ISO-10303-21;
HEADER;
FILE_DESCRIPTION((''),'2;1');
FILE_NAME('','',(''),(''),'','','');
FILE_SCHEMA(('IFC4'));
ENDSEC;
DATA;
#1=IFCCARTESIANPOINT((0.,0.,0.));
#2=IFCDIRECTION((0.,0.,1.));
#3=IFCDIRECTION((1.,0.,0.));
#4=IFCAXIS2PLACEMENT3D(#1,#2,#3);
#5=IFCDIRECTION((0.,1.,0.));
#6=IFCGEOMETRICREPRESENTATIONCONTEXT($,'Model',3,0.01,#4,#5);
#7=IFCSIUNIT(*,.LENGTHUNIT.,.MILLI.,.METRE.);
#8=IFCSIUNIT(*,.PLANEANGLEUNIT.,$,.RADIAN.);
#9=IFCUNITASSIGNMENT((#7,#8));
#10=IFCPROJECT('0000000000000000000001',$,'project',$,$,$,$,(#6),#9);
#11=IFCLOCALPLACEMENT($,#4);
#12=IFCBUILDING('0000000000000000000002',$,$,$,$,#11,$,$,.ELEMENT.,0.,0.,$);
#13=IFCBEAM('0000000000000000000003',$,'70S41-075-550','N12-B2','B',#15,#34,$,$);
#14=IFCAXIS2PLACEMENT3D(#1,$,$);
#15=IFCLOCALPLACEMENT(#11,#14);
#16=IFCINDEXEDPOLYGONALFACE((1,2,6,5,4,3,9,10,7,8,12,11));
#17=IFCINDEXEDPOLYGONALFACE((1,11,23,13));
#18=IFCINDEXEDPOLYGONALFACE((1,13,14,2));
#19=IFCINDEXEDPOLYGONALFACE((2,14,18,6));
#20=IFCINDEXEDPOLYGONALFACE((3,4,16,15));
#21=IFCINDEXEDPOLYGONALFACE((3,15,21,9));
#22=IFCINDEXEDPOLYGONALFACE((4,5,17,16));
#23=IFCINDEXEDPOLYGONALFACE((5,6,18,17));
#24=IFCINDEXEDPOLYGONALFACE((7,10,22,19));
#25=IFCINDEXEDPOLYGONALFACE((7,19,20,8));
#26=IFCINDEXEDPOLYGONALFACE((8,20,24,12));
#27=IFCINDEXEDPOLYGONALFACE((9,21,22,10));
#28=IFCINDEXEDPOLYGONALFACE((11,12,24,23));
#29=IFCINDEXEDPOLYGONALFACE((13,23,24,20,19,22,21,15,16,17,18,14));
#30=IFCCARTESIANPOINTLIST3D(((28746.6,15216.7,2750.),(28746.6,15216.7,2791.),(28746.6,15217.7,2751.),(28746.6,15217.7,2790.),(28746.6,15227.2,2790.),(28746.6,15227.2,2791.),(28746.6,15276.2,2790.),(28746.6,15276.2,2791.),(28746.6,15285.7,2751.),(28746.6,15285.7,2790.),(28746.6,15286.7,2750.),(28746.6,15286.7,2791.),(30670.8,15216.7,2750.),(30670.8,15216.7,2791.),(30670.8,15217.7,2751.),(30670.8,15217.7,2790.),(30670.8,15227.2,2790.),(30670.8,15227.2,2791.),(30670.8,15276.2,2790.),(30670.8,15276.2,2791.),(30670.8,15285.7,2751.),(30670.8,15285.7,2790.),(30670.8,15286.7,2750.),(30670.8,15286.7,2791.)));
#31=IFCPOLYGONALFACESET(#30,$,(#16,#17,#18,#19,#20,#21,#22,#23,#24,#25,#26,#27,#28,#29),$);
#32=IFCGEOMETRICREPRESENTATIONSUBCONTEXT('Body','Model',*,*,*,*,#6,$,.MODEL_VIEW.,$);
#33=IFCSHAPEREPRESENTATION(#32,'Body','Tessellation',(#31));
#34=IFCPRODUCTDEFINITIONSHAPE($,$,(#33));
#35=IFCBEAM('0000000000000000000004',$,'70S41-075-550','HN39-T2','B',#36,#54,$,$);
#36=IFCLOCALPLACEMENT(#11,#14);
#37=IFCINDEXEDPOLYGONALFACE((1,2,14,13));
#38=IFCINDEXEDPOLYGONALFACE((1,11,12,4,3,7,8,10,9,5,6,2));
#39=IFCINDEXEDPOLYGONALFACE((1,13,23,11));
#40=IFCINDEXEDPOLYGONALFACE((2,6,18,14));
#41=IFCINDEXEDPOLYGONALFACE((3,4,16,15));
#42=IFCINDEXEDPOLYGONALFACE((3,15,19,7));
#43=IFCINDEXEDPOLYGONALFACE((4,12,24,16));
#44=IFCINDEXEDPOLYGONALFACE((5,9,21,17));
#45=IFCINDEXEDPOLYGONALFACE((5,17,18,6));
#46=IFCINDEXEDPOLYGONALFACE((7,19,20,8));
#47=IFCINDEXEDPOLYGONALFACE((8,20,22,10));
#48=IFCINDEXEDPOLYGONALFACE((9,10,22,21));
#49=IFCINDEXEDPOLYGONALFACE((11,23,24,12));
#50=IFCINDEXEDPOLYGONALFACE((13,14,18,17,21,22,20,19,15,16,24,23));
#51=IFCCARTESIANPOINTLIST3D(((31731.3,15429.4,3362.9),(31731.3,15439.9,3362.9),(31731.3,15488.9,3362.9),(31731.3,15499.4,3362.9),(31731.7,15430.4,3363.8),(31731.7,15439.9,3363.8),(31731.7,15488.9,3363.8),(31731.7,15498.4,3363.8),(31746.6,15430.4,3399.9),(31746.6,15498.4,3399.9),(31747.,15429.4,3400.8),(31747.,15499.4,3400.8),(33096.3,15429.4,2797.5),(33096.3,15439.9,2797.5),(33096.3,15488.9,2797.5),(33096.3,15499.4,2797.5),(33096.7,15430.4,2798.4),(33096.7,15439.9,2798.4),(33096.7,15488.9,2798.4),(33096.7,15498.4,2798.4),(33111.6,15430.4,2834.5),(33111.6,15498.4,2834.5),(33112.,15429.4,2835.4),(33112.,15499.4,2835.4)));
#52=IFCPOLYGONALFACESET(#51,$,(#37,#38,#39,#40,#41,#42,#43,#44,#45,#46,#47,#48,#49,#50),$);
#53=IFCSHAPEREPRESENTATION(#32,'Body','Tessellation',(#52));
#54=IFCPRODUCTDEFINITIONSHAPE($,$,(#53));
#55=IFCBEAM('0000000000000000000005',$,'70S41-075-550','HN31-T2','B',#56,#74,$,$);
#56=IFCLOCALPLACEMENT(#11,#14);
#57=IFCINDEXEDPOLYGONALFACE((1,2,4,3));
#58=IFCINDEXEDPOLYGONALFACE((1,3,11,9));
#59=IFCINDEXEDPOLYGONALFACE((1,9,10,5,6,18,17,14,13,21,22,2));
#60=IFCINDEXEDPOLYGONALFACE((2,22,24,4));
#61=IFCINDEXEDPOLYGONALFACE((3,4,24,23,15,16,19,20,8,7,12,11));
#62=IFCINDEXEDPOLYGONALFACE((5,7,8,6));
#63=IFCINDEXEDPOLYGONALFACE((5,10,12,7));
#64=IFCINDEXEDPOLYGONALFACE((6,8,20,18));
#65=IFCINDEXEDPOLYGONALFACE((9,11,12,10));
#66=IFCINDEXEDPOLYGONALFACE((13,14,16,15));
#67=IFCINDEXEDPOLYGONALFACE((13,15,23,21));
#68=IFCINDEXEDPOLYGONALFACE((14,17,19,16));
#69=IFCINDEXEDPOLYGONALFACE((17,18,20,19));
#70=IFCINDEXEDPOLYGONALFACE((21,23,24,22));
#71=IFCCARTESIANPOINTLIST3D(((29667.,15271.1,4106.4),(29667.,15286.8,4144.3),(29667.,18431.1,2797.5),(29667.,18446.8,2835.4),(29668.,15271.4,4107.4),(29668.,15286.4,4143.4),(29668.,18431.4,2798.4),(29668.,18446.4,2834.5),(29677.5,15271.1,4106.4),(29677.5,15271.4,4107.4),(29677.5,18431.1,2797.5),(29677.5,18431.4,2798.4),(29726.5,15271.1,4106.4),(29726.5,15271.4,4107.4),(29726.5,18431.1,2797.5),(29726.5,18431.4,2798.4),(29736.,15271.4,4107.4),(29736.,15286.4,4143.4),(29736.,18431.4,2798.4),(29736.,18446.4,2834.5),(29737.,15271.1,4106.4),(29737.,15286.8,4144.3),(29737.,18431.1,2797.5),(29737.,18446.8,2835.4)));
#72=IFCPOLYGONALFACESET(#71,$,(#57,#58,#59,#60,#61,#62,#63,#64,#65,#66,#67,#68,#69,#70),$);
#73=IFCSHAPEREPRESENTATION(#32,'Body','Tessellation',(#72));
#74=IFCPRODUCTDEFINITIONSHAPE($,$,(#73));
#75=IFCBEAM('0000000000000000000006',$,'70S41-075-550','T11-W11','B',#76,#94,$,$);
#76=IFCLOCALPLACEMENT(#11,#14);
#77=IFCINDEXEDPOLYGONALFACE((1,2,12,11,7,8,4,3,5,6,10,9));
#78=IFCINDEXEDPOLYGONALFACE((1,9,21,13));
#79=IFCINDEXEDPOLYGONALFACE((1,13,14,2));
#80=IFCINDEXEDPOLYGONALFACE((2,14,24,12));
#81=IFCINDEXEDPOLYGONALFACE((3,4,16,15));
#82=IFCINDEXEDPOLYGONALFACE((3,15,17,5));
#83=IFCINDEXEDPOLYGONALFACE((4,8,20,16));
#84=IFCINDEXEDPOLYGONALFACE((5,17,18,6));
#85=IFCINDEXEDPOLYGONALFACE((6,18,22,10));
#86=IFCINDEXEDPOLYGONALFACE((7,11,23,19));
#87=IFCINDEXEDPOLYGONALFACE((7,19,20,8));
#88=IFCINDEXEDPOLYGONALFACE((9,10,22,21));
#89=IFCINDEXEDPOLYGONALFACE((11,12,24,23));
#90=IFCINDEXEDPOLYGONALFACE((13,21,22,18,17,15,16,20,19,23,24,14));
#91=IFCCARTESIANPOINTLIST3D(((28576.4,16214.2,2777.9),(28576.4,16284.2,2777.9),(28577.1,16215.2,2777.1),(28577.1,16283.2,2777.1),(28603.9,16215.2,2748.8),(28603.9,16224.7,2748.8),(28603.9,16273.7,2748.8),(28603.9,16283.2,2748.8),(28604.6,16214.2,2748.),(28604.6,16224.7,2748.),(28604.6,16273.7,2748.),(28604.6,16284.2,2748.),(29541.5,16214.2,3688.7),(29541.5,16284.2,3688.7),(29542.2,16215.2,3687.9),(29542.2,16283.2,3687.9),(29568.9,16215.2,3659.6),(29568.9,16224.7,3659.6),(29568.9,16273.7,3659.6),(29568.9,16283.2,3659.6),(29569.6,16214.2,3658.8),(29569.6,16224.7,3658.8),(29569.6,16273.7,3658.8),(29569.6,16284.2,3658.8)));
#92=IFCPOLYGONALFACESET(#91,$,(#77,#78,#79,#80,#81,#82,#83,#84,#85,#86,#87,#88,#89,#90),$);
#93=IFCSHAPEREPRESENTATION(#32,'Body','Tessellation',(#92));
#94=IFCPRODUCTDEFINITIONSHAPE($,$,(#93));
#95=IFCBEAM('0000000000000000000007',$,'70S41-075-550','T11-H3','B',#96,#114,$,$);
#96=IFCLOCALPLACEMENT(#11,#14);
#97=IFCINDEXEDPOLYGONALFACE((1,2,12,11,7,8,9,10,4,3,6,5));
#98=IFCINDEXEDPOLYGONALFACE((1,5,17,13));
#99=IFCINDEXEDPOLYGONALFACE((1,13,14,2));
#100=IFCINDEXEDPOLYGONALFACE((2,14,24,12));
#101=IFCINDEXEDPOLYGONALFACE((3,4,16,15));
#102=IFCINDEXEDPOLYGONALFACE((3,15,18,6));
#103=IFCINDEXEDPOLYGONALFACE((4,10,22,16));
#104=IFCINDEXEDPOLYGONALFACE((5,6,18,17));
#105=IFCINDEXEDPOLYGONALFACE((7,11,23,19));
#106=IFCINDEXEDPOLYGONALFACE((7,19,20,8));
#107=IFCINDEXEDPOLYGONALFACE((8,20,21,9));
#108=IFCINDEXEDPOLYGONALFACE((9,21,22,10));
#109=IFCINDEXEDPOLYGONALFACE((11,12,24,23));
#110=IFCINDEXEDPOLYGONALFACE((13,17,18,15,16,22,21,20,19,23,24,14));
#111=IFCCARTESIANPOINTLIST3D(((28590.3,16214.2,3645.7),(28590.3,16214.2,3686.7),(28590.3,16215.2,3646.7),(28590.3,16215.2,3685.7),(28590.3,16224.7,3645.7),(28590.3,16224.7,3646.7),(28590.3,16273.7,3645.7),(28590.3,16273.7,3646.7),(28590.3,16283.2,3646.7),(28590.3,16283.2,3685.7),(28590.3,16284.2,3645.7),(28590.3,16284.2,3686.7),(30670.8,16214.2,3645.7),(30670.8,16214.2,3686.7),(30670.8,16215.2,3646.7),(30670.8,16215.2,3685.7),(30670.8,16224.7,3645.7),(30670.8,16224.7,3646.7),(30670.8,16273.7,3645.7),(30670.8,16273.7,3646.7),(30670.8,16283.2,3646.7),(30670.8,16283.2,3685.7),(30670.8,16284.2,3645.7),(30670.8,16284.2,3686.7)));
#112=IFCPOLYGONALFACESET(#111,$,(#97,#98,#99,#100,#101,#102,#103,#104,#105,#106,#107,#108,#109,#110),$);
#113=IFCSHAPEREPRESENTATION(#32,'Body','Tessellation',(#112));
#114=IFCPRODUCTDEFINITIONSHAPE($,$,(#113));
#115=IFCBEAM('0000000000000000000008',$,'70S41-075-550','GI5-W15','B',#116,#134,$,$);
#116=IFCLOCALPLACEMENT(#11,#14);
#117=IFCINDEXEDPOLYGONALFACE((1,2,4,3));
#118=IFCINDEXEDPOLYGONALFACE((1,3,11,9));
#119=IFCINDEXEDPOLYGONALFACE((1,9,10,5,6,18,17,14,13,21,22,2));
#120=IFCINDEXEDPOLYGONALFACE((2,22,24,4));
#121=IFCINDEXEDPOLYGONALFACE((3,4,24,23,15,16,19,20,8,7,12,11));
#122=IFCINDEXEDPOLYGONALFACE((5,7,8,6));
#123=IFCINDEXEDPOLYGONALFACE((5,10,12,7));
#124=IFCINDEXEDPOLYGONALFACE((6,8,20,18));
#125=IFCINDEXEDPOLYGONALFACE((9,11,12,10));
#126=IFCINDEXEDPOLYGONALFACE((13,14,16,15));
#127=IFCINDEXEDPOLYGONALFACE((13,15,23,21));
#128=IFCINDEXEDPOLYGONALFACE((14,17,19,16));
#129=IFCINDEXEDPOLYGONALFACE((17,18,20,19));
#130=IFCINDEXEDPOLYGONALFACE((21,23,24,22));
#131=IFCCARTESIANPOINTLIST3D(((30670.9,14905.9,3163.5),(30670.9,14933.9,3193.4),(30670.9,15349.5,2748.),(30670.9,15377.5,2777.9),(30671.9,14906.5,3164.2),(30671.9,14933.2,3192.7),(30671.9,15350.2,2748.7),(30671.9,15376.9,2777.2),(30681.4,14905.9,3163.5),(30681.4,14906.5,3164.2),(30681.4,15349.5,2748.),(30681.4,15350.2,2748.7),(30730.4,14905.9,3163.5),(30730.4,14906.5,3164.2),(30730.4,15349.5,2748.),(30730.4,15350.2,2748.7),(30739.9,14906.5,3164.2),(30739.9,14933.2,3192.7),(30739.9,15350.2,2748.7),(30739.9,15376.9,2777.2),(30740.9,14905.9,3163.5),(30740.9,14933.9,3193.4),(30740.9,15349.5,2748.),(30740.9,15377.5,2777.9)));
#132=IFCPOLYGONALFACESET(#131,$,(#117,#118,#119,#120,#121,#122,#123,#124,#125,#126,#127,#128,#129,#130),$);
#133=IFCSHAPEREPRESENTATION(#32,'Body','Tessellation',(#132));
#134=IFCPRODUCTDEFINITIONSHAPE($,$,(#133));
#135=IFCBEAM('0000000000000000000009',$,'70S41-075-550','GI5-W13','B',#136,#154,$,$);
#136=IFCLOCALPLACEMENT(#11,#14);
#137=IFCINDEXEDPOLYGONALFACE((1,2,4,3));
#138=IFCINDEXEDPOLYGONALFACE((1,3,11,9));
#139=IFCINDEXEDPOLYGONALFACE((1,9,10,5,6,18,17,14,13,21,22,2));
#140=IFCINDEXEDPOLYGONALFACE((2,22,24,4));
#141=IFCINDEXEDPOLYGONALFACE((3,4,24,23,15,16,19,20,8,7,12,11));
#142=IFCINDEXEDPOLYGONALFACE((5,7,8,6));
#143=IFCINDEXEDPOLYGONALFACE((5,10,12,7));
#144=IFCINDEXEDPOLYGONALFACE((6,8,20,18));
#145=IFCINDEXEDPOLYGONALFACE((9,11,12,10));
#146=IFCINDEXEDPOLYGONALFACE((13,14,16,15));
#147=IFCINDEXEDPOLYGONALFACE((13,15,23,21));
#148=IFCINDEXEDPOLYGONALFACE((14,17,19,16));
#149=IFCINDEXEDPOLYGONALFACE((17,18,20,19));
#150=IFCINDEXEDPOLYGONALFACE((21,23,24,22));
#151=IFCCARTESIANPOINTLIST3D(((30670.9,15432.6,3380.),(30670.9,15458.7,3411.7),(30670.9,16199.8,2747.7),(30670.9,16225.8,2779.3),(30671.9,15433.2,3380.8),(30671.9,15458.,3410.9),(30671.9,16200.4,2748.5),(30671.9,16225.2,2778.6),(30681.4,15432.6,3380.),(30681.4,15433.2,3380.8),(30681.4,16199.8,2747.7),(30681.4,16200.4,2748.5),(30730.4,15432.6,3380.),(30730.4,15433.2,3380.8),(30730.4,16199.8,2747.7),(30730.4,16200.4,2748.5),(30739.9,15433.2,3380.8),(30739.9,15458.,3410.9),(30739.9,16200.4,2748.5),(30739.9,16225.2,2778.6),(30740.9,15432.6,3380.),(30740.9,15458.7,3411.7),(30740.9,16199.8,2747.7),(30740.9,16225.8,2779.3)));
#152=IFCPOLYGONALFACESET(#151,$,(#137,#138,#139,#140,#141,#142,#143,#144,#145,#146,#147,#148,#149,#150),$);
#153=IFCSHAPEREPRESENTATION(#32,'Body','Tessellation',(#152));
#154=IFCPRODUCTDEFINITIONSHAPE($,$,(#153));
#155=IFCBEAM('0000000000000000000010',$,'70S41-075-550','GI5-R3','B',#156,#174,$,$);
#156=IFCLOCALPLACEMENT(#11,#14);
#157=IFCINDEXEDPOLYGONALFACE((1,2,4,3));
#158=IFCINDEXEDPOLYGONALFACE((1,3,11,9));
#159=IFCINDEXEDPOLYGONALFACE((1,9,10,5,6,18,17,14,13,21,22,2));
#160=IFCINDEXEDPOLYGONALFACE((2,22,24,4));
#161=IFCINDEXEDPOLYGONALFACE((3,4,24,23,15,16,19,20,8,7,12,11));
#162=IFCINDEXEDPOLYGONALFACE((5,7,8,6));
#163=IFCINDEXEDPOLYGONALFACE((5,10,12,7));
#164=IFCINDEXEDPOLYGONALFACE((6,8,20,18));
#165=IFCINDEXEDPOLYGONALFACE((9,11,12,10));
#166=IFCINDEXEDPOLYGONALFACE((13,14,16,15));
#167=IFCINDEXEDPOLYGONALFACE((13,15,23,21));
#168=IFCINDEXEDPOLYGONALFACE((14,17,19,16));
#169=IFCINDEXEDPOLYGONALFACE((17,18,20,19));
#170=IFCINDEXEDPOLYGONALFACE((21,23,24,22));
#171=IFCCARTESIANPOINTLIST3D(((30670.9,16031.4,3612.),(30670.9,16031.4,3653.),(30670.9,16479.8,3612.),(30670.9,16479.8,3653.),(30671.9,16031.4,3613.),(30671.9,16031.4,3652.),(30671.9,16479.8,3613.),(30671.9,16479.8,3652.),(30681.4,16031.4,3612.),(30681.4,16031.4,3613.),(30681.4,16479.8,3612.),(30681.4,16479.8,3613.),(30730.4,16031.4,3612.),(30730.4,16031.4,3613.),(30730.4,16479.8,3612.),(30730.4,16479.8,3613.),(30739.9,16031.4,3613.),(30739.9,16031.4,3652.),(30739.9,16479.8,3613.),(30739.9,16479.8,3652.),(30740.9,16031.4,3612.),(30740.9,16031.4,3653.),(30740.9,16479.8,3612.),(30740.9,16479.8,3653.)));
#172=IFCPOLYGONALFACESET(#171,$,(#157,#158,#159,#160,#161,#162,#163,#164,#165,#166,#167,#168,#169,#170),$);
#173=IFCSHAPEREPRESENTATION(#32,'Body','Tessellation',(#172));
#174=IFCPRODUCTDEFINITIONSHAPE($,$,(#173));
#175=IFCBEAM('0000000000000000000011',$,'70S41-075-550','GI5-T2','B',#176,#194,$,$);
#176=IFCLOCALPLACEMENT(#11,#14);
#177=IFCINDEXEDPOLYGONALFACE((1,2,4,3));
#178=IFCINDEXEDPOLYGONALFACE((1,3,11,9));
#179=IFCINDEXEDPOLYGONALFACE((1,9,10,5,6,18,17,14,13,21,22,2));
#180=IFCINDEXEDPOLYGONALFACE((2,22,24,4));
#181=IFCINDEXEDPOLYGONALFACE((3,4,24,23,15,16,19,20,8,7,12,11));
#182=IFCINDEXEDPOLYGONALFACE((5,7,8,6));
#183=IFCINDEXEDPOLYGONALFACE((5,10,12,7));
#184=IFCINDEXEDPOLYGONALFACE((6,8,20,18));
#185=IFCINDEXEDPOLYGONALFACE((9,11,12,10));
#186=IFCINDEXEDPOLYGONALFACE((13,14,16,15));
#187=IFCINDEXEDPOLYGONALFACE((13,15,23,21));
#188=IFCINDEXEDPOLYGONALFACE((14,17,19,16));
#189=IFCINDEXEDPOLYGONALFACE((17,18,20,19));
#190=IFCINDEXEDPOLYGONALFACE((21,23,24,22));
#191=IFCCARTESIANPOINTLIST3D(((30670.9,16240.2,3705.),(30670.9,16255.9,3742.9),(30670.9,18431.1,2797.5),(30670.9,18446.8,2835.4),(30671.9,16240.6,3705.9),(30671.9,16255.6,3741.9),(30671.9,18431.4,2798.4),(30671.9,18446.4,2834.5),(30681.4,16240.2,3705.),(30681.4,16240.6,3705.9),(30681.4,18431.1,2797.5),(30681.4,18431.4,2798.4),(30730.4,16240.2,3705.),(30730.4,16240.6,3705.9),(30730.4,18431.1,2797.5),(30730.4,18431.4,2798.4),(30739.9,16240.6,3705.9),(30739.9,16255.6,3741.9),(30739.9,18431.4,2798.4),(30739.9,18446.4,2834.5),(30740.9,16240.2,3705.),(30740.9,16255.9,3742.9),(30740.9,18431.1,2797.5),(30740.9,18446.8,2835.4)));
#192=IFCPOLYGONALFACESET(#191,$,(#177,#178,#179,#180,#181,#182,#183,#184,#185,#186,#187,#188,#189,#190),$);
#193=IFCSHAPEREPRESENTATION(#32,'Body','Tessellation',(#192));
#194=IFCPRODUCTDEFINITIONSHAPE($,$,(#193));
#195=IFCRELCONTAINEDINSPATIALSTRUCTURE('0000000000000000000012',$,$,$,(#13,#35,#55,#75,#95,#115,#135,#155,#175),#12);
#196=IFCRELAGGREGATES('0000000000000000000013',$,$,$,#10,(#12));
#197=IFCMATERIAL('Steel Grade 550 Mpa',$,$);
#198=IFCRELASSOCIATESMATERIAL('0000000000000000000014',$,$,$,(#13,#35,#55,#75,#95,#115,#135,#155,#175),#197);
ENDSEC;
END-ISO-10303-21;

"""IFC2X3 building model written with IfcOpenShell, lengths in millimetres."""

from ifc_helpers import new_model, si_unit, direction, frame, origin, origin_with_axes, origin_2d_with_axis, place, context, subcontext, project, spatial, c_section, extrude, source, transform, mapped, material, element, save


model = new_model("IFC2X3")

# Units and contexts
model_context = context("Model", 3, precision=0.01, world=origin_with_axes(), true_north=direction((0.0, 1.0, 0.0)))
body_context = subcontext(model_context, "Body", "Model", "MODEL_VIEW")
ifc_project = project(units=[si_unit("LENGTHUNIT", "METRE", prefix="MILLI"), si_unit("PLANEANGLEUNIT", "RADIAN")], contexts=[model_context])

# Building
building_placement = place(None, origin_with_axes())
building = spatial("IfcBuilding", under=ifc_project, at=building_placement, CompositionType="ELEMENT", ElevationOfRefHeight=0.0, ElevationOfTerrain=0.0)

# Shared definitions
ifc_material = material(Name="Steel Grade 550 Mpa")

# Beams
shared_shape_1 = source(origin(), body_context, "Body", "SweptSolid", [
    extrude(c_section(Depth=70.0, Width=41.0, WallThickness=1.0, Girth=10.5, at=origin_2d_with_axis()), origin_with_axes(), (0.0, 0.0, 1.0), 1924.2),
])
beam_1_placement = place(None, frame((28746.6, 15251.7, 2770.5), z_axis=(1.0, 0.0, 0.0), x_axis=(0.0, 0.0, 1.0)))
element("IfcBeam", 1, at=beam_1_placement, inside=building, material=ifc_material, Name="70S41-075-550", Description="N12-B2", ObjectType="B", context=body_context, shape_type="MappedRepresentation", body=[
    mapped(shared_shape_1, transform((0.0, 0.0, 0.0), scale=1.0)),
])
shared_shape_2 = source(origin(), body_context, "Body", "SweptSolid", [
    extrude(c_section(Depth=70.0, Width=41.0, WallThickness=1.0, Girth=10.5, at=origin_2d_with_axis()), origin_with_axes(), (0.0, 0.0, 1.0), 1477.5),
])
beam_2_placement = place(None, frame((31739.2, 15464.4, 3381.9), z_axis=(0.92388, 0.0, -0.382683), x_axis=(-0.382683, 0.0, -0.92388)))
element("IfcBeam", 2, at=beam_2_placement, inside=building, material=ifc_material, Name="70S41-075-550", Description="HN39-T2", ObjectType="B", context=body_context, shape_type="MappedRepresentation", body=[
    mapped(shared_shape_2, transform((0.0, 0.0, 0.0), scale=1.0)),
])
shared_shape_3 = source(origin(), body_context, "Body", "SweptSolid", [
    extrude(c_section(Depth=70.0, Width=41.0, WallThickness=1.0, Girth=10.5, at=origin_2d_with_axis()), origin_with_axes(), (0.0, 0.0, 1.0), 3420.4),
])
beam_3_placement = place(None, frame((29702.0, 15278.9, 4125.4), z_axis=(0.0, 0.92388, -0.382683), x_axis=(0.0, -0.382683, -0.92388)))
element("IfcBeam", 3, at=beam_3_placement, inside=building, material=ifc_material, Name="70S41-075-550", Description="HN31-T2", ObjectType="B", context=body_context, shape_type="MappedRepresentation", body=[
    mapped(shared_shape_3, transform((0.0, 0.0, 0.0), scale=1.0)),
])
shared_shape_4 = source(origin(), body_context, "Body", "SweptSolid", [
    extrude(c_section(Depth=70.0, Width=41.0, WallThickness=1.0, Girth=10.5, at=origin_2d_with_axis()), origin_with_axes(), (0.0, 0.0, 1.0), 1327.0),
])
beam_4_placement = place(None, frame((29555.5, 16249.2, 3673.8), z_axis=(-0.727249, 0.0, -0.686374), x_axis=(0.686374, 0.0, -0.727249)))
element("IfcBeam", 4, at=beam_4_placement, inside=building, material=ifc_material, Name="70S41-075-550", Description="T11-W11", ObjectType="B", context=body_context, shape_type="MappedRepresentation", body=[
    mapped(shared_shape_4, transform((0.0, 0.0, 0.0), scale=1.0)),
])
shared_shape_5 = source(origin(), body_context, "Body", "SweptSolid", [
    extrude(c_section(Depth=70.0, Width=41.0, WallThickness=1.0, Girth=10.5, at=origin_2d_with_axis()), origin_with_axes(), (0.0, 0.0, 1.0), 2080.5),
])
beam_5_placement = place(None, frame((30670.8, 16249.2, 3666.2), z_axis=(-1.0, 0.0, 0.0), x_axis=(0.0, 0.0, -1.0)))
element("IfcBeam", 5, at=beam_5_placement, inside=building, material=ifc_material, Name="70S41-075-550", Description="T11-H3", ObjectType="B", context=body_context, shape_type="MappedRepresentation", body=[
    mapped(shared_shape_5, transform((0.0, 0.0, 0.0), scale=1.0)),
])
shared_shape_6 = source(origin(), body_context, "Body", "SweptSolid", [
    extrude(c_section(Depth=70.0, Width=41.0, WallThickness=1.0, Girth=10.5, at=origin_2d_with_axis()), origin_with_axes(), (0.0, 0.0, 1.0), 607.8),
])
beam_6_placement = place(None, frame((30705.9, 14919.9, 3178.4), z_axis=(0.0, 0.729939, -0.683513), x_axis=(0.0, -0.683513, -0.729939)))
element("IfcBeam", 6, at=beam_6_placement, inside=building, material=ifc_material, Name="70S41-075-550", Description="GI5-W15", ObjectType="B", context=body_context, shape_type="MappedRepresentation", body=[
    mapped(shared_shape_6, transform((0.0, 0.0, 0.0), scale=1.0)),
])
shared_shape_7 = source(origin(), body_context, "Body", "SweptSolid", [
    extrude(c_section(Depth=70.0, Width=41.0, WallThickness=1.0, Girth=10.5, at=origin_2d_with_axis()), origin_with_axes(), (0.0, 0.0, 1.0), 994.2),
])
beam_7_placement = place(None, frame((30705.9, 15445.6, 3395.9), z_axis=(0.0, 0.771652, -0.636045), x_axis=(0.0, -0.636045, -0.771652)))
element("IfcBeam", 7, at=beam_7_placement, inside=building, material=ifc_material, Name="70S41-075-550", Description="GI5-W13", ObjectType="B", context=body_context, shape_type="MappedRepresentation", body=[
    mapped(shared_shape_7, transform((0.0, 0.0, 0.0), scale=1.0)),
])
shared_shape_8 = source(origin(), body_context, "Body", "SweptSolid", [
    extrude(c_section(Depth=70.0, Width=41.0, WallThickness=1.0, Girth=10.5, at=origin_2d_with_axis()), origin_with_axes(), (0.0, 0.0, 1.0), 448.4),
])
beam_8_placement = place(None, frame((30705.9, 16031.4, 3632.5), z_axis=(0.0, 1.0, 0.0), x_axis=(0.0, 0.0, -1.0)))
element("IfcBeam", 8, at=beam_8_placement, inside=building, material=ifc_material, Name="70S41-075-550", Description="GI5-R3", ObjectType="B", context=body_context, shape_type="MappedRepresentation", body=[
    mapped(shared_shape_8, transform((0.0, 0.0, 0.0), scale=1.0)),
])
shared_shape_9 = source(origin(), body_context, "Body", "SweptSolid", [
    extrude(c_section(Depth=70.0, Width=41.0, WallThickness=1.0, Girth=10.5, at=origin_2d_with_axis()), origin_with_axes(), (0.0, 0.0, 1.0), 2371.3),
])
beam_9_placement = place(None, frame((30705.9, 16248.1, 3723.9), z_axis=(0.0, 0.92388, -0.382683), x_axis=(0.0, -0.382683, -0.92388)))
element("IfcBeam", 9, at=beam_9_placement, inside=building, material=ifc_material, Name="70S41-075-550", Description="GI5-T2", ObjectType="B", context=body_context, shape_type="MappedRepresentation", body=[
    mapped(shared_shape_9, transform((0.0, 0.0, 0.0), scale=1.0)),
])

save(model, "model.ifc")
